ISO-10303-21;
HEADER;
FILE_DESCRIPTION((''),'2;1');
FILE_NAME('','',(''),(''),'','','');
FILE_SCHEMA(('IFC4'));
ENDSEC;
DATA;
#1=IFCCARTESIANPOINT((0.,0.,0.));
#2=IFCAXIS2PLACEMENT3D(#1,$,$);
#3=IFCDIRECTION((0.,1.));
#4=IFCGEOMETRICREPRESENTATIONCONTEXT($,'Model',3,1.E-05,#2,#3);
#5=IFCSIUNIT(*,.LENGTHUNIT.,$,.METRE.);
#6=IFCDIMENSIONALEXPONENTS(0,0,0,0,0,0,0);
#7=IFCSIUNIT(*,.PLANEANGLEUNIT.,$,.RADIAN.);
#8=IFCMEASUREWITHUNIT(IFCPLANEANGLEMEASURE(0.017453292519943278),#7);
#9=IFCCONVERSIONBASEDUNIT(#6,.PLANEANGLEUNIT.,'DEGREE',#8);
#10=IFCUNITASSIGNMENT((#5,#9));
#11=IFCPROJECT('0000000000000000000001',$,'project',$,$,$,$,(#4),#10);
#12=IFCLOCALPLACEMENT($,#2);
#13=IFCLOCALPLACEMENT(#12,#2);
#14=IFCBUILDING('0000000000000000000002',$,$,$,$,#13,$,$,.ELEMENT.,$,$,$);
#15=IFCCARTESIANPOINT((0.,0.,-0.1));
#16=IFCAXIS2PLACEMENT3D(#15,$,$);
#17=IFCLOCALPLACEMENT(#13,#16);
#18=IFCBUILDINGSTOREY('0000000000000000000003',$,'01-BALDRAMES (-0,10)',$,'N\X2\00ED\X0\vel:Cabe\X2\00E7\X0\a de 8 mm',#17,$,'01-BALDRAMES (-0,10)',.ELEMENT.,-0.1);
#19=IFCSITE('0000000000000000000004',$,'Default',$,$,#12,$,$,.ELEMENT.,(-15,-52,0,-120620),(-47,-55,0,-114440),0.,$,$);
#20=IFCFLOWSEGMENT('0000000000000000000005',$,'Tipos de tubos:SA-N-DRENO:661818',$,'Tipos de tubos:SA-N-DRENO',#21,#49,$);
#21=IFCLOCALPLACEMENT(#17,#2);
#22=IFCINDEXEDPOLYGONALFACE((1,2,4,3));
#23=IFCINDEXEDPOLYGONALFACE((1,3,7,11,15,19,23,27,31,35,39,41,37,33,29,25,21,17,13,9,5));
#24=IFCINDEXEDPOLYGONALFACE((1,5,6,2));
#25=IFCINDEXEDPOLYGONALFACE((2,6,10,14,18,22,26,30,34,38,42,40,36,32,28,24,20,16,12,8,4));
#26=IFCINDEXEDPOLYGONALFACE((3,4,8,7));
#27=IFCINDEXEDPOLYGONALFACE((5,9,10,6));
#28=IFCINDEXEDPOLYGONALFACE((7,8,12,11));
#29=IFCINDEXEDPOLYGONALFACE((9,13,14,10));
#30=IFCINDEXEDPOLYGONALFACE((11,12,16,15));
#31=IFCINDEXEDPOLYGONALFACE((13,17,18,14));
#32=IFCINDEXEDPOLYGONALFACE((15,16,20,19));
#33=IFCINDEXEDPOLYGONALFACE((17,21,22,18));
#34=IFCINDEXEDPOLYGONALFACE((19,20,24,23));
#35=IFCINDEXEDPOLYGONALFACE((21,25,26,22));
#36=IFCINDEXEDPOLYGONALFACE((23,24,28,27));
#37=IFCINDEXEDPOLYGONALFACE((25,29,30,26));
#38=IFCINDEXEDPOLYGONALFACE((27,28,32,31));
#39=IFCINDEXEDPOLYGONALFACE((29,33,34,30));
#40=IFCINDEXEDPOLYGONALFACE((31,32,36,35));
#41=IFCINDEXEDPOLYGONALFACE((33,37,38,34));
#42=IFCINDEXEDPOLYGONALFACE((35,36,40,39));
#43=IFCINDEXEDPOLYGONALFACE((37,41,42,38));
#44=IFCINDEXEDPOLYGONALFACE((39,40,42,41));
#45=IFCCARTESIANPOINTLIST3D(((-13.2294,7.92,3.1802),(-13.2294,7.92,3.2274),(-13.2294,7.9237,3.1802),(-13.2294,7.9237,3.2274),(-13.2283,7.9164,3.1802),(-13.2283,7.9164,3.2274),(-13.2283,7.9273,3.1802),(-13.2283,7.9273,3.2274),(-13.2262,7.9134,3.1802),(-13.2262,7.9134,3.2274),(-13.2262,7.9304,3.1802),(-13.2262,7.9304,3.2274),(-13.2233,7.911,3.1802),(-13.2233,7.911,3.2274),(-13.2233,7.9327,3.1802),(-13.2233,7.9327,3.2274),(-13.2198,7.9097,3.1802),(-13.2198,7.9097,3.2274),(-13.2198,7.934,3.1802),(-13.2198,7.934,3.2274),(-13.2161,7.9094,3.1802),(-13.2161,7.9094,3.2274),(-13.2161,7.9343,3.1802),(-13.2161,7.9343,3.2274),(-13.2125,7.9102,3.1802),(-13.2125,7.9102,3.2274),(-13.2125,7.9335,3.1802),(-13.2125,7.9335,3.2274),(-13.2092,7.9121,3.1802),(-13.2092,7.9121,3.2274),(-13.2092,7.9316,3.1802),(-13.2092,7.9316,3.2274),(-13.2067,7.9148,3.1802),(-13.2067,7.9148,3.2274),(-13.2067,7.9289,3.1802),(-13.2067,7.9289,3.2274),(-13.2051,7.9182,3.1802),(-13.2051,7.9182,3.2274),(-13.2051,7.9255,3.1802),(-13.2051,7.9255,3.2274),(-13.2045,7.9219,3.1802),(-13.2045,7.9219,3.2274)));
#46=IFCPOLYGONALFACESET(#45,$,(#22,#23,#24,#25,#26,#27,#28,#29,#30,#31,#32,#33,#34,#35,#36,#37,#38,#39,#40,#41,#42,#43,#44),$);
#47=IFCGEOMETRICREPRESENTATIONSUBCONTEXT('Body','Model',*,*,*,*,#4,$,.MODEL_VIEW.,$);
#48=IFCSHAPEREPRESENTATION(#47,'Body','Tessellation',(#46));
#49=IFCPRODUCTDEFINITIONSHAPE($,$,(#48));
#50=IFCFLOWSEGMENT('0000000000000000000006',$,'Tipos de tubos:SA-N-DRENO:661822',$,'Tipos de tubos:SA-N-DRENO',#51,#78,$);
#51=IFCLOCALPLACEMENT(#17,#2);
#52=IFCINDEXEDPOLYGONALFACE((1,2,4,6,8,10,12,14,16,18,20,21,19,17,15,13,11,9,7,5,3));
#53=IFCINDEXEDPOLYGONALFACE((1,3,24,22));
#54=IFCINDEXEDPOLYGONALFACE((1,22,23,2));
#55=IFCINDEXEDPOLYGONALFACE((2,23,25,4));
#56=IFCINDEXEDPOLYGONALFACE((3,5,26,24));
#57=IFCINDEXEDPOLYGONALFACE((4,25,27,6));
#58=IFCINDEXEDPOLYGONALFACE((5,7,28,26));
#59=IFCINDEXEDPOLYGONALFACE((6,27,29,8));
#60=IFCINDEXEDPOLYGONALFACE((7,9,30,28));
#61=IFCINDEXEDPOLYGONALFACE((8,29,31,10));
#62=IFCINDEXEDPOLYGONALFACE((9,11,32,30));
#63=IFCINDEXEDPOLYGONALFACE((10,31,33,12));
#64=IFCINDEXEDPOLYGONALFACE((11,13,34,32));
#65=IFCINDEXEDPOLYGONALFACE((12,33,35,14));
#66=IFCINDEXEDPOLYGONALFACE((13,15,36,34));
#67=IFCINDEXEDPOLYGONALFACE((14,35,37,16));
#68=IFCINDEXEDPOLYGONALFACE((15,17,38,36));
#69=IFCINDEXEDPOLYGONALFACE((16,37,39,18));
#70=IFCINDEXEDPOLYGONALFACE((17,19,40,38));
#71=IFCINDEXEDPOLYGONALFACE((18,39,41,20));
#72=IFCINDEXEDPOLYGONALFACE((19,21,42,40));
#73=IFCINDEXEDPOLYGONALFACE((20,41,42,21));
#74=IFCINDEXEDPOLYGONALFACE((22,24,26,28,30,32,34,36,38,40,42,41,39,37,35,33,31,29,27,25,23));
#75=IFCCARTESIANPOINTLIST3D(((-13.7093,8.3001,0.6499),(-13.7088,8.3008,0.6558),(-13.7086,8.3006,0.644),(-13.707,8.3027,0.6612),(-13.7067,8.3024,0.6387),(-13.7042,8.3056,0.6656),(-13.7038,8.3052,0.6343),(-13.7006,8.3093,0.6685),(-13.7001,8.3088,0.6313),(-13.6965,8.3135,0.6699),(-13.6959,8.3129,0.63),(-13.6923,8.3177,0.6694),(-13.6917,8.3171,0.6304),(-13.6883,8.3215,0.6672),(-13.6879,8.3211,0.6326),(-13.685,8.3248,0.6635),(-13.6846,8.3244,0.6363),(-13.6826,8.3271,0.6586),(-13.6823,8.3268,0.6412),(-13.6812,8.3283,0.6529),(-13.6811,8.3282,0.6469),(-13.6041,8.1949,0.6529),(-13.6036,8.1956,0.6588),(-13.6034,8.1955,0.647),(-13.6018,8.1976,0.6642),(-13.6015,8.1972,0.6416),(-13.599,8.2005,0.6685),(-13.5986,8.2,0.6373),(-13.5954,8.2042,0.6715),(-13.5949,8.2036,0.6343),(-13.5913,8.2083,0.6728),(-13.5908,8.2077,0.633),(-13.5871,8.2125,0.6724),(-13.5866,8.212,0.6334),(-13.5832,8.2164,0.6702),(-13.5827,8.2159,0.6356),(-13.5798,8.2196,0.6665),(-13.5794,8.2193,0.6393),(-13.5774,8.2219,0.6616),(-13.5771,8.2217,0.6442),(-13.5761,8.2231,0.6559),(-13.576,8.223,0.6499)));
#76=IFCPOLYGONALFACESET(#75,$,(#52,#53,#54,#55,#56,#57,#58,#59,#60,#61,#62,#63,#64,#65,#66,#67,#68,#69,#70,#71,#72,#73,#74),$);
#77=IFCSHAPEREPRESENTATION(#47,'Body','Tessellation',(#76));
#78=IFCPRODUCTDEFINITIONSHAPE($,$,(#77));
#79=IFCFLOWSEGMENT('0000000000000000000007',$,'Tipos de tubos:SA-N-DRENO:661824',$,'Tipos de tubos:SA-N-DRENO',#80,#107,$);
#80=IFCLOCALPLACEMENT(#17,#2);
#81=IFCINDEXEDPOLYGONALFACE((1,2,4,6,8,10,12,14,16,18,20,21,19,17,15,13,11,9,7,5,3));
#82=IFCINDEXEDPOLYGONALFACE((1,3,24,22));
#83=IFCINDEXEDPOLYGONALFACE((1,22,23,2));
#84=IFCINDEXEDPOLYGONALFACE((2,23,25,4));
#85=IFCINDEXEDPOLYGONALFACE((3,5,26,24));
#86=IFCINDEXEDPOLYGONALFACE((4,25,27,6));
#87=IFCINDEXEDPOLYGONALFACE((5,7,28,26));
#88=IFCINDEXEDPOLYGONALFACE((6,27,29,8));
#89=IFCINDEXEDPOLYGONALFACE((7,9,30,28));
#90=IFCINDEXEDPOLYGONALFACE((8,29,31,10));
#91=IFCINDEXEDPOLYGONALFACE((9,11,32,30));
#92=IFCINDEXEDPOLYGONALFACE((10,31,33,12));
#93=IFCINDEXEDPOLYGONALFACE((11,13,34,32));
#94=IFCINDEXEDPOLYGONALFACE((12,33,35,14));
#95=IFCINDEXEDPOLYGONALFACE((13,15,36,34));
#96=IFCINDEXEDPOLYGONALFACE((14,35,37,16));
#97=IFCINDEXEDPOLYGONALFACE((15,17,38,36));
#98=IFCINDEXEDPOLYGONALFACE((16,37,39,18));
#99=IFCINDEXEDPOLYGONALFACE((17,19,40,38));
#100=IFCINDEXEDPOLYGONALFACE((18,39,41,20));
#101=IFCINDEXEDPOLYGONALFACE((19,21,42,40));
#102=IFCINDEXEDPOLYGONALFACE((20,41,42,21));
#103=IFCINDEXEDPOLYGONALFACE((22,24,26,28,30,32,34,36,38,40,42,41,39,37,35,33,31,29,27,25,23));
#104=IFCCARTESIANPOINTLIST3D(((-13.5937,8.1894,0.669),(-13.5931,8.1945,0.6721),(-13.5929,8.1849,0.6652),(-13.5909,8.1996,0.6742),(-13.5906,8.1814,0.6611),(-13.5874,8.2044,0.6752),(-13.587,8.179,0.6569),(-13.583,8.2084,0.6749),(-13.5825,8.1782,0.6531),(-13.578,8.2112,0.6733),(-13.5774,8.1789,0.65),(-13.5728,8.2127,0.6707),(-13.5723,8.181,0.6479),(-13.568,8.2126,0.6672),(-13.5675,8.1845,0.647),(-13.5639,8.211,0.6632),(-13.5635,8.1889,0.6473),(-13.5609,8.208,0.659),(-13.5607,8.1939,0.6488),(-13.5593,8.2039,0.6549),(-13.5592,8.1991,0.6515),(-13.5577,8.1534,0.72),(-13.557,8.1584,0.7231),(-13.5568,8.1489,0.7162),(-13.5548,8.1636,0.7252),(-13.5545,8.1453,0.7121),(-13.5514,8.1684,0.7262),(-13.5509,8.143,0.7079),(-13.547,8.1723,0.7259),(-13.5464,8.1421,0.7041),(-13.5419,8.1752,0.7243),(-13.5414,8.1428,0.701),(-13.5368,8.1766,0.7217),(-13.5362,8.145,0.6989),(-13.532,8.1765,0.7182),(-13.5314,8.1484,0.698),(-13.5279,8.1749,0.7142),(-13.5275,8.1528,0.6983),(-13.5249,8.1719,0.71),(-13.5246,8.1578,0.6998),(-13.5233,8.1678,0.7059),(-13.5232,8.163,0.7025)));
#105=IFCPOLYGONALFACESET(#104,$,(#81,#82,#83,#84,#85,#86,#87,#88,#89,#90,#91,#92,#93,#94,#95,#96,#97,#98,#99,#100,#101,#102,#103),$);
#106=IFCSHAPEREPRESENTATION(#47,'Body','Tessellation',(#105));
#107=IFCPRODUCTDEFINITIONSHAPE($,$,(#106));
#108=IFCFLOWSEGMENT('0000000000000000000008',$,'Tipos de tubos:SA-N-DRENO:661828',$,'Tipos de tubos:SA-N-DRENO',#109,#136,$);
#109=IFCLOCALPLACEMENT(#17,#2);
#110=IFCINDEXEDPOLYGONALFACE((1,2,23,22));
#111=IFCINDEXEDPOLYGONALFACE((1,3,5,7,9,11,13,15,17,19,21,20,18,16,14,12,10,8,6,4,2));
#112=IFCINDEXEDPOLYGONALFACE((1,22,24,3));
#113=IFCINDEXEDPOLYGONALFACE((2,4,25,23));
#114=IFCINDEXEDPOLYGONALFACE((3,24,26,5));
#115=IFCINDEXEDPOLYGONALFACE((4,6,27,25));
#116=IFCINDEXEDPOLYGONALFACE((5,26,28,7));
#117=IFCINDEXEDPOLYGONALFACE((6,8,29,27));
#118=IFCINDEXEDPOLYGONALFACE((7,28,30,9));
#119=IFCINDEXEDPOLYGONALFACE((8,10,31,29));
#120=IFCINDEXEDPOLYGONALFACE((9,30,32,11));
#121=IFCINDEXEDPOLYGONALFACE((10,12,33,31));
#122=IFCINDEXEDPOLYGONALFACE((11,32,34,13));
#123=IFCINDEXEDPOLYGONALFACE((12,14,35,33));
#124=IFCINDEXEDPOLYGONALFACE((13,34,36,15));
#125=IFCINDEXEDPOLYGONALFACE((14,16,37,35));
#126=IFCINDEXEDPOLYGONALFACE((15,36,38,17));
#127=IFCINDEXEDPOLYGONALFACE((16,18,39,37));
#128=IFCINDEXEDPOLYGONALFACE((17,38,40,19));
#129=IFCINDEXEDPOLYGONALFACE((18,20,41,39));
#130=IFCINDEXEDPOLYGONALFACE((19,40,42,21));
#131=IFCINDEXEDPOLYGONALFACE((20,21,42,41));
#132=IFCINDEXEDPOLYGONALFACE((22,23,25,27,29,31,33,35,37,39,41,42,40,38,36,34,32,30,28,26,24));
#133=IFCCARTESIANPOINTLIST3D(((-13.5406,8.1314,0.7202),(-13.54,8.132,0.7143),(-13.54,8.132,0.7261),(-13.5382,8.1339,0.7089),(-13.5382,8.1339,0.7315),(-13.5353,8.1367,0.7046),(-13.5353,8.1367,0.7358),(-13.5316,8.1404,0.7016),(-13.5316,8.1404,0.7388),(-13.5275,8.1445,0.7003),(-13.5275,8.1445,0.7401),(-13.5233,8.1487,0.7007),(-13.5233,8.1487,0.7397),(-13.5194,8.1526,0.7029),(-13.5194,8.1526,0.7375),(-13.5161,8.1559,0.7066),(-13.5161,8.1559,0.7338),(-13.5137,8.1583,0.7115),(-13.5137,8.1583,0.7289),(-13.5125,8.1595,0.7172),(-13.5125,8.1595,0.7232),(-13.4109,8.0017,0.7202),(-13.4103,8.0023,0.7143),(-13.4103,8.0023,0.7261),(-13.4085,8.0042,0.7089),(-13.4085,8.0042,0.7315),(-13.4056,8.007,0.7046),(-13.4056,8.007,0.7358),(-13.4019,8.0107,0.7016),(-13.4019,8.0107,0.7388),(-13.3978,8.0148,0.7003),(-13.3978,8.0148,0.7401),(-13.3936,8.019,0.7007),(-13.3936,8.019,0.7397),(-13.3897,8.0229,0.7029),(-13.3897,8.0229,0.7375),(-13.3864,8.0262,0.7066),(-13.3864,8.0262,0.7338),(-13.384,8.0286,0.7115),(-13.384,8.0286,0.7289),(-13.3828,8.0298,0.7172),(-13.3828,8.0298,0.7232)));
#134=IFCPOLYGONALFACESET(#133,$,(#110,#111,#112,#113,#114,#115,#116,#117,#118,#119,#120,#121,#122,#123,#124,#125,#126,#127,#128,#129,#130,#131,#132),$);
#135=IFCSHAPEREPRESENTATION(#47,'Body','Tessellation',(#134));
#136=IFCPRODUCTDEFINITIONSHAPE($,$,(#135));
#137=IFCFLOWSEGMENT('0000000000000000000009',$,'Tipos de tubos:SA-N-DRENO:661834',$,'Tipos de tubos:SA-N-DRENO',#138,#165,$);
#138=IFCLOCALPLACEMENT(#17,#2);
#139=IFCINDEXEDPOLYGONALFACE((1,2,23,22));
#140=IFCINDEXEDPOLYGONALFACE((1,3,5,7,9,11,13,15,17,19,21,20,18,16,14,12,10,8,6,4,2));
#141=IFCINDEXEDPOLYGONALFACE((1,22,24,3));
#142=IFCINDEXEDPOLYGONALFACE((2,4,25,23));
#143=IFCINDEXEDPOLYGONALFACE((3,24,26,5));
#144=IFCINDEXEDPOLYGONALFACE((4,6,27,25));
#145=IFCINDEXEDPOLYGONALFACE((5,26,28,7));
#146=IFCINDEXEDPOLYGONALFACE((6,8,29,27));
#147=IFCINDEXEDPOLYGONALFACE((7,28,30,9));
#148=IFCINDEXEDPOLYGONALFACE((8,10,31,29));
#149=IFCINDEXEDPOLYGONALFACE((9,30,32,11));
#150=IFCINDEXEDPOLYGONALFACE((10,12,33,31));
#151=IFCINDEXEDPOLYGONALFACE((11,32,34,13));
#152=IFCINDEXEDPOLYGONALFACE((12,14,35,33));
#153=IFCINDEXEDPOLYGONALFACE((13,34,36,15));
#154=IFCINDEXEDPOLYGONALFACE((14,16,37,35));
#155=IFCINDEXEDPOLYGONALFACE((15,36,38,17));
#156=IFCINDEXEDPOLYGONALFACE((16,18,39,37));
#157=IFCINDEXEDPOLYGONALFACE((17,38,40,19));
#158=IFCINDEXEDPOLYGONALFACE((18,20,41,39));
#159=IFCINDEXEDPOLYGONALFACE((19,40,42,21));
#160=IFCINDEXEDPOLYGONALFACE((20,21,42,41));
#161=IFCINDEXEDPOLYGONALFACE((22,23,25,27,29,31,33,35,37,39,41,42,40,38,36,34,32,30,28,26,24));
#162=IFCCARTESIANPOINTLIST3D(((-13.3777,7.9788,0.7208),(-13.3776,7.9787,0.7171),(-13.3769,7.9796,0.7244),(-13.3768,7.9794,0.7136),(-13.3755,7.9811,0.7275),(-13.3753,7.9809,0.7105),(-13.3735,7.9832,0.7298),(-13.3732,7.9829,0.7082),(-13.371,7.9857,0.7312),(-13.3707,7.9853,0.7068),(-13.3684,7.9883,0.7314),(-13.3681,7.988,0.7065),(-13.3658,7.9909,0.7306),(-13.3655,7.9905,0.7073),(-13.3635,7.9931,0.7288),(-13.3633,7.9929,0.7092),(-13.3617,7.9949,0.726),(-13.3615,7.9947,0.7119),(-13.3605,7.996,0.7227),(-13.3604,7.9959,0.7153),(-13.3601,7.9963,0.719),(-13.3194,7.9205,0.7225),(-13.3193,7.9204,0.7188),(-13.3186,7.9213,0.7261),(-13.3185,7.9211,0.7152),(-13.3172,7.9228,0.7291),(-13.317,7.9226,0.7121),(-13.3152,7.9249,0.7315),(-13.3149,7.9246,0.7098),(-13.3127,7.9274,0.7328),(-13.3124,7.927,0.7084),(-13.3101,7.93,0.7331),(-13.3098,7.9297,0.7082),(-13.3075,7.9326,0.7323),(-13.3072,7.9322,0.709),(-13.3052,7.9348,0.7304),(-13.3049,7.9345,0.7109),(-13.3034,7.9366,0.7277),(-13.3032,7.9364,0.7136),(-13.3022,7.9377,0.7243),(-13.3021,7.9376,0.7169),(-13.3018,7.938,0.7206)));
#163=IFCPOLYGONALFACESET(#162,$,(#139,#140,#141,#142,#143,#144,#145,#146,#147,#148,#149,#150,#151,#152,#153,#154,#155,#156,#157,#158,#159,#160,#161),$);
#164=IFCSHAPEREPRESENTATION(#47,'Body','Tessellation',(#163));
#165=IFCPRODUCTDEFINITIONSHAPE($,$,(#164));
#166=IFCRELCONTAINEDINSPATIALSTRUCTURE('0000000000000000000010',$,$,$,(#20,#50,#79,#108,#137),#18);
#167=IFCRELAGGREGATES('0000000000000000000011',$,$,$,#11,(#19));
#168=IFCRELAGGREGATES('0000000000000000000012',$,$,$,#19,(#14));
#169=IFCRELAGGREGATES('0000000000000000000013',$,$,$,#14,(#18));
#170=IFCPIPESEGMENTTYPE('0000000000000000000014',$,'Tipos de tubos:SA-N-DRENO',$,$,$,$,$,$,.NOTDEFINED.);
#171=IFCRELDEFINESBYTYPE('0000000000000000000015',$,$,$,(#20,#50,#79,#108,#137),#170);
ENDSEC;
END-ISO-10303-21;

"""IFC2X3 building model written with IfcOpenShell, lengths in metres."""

from ifc_helpers import new_model, entity, si_unit, converted_unit, direction, frame, frame_2d, origin, origin_2d_with_axis, place, context, subcontext, project, spatial, circle, extrude, type_object, element, save


model = new_model("IFC2X3")

# Units and contexts
model_context = context("Model", 3, precision=1e-05, world=origin(), true_north=direction((0.0, 1.0)))
body_context = subcontext(model_context, "Body", "Model", "MODEL_VIEW")
ifc_project = project(units=[si_unit("LENGTHUNIT", "METRE"), converted_unit("PLANEANGLEUNIT", "DEGREE", entity("IfcPlaneAngleMeasure", 0.017453292519943278), si_unit("PLANEANGLEUNIT", "RADIAN"), dimensions=[0, 0, 0, 0, 0, 0, 0])], contexts=[model_context])

# Site, building, storey
site_placement = place(None, origin())
site = spatial("IfcSite", under=ifc_project, at=site_placement, Name="Default", CompositionType="ELEMENT", RefLatitude=(-15, -52, 0, -120620), RefLongitude=(-47, -55, 0, -114440), RefElevation=0.0)
building_placement = place(site_placement, origin())
building = spatial("IfcBuilding", under=site, at=building_placement, CompositionType="ELEMENT")
storey_placement = place(building_placement, frame((0.0, 0.0, -0.1)))
storey = spatial("IfcBuildingStorey", under=building, at=storey_placement, Name="01-BALDRAMES (-0,10)", ObjectType="Nível:Cabeça de 8 mm", LongName="01-BALDRAMES (-0,10)", CompositionType="ELEMENT", Elevation=-0.1)

# Flow segments
pipe_segment_type_1 = type_object("IfcPipeSegmentType", Name="Tipos de tubos:SA-N-DRENO", PredefinedType="NOTDEFINED")
flow_segment_1_placement = place(storey_placement, origin())
element("IfcFlowSegment", 1, at=flow_segment_1_placement, inside=storey, type_object=pipe_segment_type_1, Name="Tipos de tubos:SA-N-DRENO:661818", ObjectType="Tipos de tubos:SA-N-DRENO", context=body_context, shape_type="SweptSolid", body=[
    extrude(circle(Radius=0.0125, at=frame_2d((0.0, 0.0), x_axis=(1.0, 0.0))), frame((-13.217, 7.9219, 3.1802)), (0.0, 0.0, 1.0), 0.0471),
])
flow_segment_2_placement = place(storey_placement, origin())
element("IfcFlowSegment", 2, at=flow_segment_2_placement, inside=storey, type_object=pipe_segment_type_1, Name="Tipos de tubos:SA-N-DRENO:661822", ObjectType="Tipos de tubos:SA-N-DRENO", context=body_context, shape_type="SweptSolid", body=[
    extrude(circle(Radius=0.02, at=frame_2d((0.0, 0.0), x_axis=(1.0, 0.0))), frame((-13.59, 8.2091, 0.6529), z_axis=(-0.707037, 0.706894, -0.019996), x_axis=(-0.707036, -0.707178, 0.0)), (0.0, 0.0, 1.0), 0.1487),
])
flow_segment_3_placement = place(storey_placement, origin())
element("IfcFlowSegment", 3, at=flow_segment_3_placement, inside=storey, type_object=pipe_segment_type_1, Name="Tipos de tubos:SA-N-DRENO:661824", ObjectType="Tipos de tubos:SA-N-DRENO", context=body_context, shape_type="SweptSolid", body=[
    extrude(circle(Radius=0.02, at=frame_2d((0.0, 0.0), x_axis=(1.0, 0.0))), frame((-13.5764, 8.1955, 0.6611), z_axis=(0.5, -0.5, 0.707107), x_axis=(-0.707106, -0.707107, 0.0)), (0.0, 0.0, 1.0), 0.0721),
])
flow_segment_4_placement = place(storey_placement, origin())
element("IfcFlowSegment", 4, at=flow_segment_4_placement, inside=storey, type_object=pipe_segment_type_1, Name="Tipos de tubos:SA-N-DRENO:661828", ObjectType="Tipos de tubos:SA-N-DRENO", context=body_context, shape_type="SweptSolid", body=[
    extrude(circle(Radius=0.02, at=origin_2d_with_axis()), frame((-13.3968, 8.0159, 0.7202), z_axis=(-0.707107, 0.707106, 0.0), x_axis=(-0.707106, -0.707107, 0.0)), (0.0, 0.0, 1.0), 0.1834),
])
flow_segment_5_placement = place(storey_placement, origin())
element("IfcFlowSegment", 5, at=flow_segment_5_placement, inside=storey, type_object=pipe_segment_type_1, Name="Tipos de tubos:SA-N-DRENO:661834", ObjectType="Tipos de tubos:SA-N-DRENO", context=body_context, shape_type="SweptSolid", body=[
    extrude(circle(Radius=0.0125, at=frame_2d((0.0, 0.0), x_axis=(1.0, 0.0))), frame((-13.3106, 7.9292, 0.7206), z_axis=(-0.707043, 0.706888, -0.019996), x_axis=(0.707029, 0.707184, 0.0)), (0.0, 0.0, 1.0), 0.0825),
])

save(model, "model.ifc")
